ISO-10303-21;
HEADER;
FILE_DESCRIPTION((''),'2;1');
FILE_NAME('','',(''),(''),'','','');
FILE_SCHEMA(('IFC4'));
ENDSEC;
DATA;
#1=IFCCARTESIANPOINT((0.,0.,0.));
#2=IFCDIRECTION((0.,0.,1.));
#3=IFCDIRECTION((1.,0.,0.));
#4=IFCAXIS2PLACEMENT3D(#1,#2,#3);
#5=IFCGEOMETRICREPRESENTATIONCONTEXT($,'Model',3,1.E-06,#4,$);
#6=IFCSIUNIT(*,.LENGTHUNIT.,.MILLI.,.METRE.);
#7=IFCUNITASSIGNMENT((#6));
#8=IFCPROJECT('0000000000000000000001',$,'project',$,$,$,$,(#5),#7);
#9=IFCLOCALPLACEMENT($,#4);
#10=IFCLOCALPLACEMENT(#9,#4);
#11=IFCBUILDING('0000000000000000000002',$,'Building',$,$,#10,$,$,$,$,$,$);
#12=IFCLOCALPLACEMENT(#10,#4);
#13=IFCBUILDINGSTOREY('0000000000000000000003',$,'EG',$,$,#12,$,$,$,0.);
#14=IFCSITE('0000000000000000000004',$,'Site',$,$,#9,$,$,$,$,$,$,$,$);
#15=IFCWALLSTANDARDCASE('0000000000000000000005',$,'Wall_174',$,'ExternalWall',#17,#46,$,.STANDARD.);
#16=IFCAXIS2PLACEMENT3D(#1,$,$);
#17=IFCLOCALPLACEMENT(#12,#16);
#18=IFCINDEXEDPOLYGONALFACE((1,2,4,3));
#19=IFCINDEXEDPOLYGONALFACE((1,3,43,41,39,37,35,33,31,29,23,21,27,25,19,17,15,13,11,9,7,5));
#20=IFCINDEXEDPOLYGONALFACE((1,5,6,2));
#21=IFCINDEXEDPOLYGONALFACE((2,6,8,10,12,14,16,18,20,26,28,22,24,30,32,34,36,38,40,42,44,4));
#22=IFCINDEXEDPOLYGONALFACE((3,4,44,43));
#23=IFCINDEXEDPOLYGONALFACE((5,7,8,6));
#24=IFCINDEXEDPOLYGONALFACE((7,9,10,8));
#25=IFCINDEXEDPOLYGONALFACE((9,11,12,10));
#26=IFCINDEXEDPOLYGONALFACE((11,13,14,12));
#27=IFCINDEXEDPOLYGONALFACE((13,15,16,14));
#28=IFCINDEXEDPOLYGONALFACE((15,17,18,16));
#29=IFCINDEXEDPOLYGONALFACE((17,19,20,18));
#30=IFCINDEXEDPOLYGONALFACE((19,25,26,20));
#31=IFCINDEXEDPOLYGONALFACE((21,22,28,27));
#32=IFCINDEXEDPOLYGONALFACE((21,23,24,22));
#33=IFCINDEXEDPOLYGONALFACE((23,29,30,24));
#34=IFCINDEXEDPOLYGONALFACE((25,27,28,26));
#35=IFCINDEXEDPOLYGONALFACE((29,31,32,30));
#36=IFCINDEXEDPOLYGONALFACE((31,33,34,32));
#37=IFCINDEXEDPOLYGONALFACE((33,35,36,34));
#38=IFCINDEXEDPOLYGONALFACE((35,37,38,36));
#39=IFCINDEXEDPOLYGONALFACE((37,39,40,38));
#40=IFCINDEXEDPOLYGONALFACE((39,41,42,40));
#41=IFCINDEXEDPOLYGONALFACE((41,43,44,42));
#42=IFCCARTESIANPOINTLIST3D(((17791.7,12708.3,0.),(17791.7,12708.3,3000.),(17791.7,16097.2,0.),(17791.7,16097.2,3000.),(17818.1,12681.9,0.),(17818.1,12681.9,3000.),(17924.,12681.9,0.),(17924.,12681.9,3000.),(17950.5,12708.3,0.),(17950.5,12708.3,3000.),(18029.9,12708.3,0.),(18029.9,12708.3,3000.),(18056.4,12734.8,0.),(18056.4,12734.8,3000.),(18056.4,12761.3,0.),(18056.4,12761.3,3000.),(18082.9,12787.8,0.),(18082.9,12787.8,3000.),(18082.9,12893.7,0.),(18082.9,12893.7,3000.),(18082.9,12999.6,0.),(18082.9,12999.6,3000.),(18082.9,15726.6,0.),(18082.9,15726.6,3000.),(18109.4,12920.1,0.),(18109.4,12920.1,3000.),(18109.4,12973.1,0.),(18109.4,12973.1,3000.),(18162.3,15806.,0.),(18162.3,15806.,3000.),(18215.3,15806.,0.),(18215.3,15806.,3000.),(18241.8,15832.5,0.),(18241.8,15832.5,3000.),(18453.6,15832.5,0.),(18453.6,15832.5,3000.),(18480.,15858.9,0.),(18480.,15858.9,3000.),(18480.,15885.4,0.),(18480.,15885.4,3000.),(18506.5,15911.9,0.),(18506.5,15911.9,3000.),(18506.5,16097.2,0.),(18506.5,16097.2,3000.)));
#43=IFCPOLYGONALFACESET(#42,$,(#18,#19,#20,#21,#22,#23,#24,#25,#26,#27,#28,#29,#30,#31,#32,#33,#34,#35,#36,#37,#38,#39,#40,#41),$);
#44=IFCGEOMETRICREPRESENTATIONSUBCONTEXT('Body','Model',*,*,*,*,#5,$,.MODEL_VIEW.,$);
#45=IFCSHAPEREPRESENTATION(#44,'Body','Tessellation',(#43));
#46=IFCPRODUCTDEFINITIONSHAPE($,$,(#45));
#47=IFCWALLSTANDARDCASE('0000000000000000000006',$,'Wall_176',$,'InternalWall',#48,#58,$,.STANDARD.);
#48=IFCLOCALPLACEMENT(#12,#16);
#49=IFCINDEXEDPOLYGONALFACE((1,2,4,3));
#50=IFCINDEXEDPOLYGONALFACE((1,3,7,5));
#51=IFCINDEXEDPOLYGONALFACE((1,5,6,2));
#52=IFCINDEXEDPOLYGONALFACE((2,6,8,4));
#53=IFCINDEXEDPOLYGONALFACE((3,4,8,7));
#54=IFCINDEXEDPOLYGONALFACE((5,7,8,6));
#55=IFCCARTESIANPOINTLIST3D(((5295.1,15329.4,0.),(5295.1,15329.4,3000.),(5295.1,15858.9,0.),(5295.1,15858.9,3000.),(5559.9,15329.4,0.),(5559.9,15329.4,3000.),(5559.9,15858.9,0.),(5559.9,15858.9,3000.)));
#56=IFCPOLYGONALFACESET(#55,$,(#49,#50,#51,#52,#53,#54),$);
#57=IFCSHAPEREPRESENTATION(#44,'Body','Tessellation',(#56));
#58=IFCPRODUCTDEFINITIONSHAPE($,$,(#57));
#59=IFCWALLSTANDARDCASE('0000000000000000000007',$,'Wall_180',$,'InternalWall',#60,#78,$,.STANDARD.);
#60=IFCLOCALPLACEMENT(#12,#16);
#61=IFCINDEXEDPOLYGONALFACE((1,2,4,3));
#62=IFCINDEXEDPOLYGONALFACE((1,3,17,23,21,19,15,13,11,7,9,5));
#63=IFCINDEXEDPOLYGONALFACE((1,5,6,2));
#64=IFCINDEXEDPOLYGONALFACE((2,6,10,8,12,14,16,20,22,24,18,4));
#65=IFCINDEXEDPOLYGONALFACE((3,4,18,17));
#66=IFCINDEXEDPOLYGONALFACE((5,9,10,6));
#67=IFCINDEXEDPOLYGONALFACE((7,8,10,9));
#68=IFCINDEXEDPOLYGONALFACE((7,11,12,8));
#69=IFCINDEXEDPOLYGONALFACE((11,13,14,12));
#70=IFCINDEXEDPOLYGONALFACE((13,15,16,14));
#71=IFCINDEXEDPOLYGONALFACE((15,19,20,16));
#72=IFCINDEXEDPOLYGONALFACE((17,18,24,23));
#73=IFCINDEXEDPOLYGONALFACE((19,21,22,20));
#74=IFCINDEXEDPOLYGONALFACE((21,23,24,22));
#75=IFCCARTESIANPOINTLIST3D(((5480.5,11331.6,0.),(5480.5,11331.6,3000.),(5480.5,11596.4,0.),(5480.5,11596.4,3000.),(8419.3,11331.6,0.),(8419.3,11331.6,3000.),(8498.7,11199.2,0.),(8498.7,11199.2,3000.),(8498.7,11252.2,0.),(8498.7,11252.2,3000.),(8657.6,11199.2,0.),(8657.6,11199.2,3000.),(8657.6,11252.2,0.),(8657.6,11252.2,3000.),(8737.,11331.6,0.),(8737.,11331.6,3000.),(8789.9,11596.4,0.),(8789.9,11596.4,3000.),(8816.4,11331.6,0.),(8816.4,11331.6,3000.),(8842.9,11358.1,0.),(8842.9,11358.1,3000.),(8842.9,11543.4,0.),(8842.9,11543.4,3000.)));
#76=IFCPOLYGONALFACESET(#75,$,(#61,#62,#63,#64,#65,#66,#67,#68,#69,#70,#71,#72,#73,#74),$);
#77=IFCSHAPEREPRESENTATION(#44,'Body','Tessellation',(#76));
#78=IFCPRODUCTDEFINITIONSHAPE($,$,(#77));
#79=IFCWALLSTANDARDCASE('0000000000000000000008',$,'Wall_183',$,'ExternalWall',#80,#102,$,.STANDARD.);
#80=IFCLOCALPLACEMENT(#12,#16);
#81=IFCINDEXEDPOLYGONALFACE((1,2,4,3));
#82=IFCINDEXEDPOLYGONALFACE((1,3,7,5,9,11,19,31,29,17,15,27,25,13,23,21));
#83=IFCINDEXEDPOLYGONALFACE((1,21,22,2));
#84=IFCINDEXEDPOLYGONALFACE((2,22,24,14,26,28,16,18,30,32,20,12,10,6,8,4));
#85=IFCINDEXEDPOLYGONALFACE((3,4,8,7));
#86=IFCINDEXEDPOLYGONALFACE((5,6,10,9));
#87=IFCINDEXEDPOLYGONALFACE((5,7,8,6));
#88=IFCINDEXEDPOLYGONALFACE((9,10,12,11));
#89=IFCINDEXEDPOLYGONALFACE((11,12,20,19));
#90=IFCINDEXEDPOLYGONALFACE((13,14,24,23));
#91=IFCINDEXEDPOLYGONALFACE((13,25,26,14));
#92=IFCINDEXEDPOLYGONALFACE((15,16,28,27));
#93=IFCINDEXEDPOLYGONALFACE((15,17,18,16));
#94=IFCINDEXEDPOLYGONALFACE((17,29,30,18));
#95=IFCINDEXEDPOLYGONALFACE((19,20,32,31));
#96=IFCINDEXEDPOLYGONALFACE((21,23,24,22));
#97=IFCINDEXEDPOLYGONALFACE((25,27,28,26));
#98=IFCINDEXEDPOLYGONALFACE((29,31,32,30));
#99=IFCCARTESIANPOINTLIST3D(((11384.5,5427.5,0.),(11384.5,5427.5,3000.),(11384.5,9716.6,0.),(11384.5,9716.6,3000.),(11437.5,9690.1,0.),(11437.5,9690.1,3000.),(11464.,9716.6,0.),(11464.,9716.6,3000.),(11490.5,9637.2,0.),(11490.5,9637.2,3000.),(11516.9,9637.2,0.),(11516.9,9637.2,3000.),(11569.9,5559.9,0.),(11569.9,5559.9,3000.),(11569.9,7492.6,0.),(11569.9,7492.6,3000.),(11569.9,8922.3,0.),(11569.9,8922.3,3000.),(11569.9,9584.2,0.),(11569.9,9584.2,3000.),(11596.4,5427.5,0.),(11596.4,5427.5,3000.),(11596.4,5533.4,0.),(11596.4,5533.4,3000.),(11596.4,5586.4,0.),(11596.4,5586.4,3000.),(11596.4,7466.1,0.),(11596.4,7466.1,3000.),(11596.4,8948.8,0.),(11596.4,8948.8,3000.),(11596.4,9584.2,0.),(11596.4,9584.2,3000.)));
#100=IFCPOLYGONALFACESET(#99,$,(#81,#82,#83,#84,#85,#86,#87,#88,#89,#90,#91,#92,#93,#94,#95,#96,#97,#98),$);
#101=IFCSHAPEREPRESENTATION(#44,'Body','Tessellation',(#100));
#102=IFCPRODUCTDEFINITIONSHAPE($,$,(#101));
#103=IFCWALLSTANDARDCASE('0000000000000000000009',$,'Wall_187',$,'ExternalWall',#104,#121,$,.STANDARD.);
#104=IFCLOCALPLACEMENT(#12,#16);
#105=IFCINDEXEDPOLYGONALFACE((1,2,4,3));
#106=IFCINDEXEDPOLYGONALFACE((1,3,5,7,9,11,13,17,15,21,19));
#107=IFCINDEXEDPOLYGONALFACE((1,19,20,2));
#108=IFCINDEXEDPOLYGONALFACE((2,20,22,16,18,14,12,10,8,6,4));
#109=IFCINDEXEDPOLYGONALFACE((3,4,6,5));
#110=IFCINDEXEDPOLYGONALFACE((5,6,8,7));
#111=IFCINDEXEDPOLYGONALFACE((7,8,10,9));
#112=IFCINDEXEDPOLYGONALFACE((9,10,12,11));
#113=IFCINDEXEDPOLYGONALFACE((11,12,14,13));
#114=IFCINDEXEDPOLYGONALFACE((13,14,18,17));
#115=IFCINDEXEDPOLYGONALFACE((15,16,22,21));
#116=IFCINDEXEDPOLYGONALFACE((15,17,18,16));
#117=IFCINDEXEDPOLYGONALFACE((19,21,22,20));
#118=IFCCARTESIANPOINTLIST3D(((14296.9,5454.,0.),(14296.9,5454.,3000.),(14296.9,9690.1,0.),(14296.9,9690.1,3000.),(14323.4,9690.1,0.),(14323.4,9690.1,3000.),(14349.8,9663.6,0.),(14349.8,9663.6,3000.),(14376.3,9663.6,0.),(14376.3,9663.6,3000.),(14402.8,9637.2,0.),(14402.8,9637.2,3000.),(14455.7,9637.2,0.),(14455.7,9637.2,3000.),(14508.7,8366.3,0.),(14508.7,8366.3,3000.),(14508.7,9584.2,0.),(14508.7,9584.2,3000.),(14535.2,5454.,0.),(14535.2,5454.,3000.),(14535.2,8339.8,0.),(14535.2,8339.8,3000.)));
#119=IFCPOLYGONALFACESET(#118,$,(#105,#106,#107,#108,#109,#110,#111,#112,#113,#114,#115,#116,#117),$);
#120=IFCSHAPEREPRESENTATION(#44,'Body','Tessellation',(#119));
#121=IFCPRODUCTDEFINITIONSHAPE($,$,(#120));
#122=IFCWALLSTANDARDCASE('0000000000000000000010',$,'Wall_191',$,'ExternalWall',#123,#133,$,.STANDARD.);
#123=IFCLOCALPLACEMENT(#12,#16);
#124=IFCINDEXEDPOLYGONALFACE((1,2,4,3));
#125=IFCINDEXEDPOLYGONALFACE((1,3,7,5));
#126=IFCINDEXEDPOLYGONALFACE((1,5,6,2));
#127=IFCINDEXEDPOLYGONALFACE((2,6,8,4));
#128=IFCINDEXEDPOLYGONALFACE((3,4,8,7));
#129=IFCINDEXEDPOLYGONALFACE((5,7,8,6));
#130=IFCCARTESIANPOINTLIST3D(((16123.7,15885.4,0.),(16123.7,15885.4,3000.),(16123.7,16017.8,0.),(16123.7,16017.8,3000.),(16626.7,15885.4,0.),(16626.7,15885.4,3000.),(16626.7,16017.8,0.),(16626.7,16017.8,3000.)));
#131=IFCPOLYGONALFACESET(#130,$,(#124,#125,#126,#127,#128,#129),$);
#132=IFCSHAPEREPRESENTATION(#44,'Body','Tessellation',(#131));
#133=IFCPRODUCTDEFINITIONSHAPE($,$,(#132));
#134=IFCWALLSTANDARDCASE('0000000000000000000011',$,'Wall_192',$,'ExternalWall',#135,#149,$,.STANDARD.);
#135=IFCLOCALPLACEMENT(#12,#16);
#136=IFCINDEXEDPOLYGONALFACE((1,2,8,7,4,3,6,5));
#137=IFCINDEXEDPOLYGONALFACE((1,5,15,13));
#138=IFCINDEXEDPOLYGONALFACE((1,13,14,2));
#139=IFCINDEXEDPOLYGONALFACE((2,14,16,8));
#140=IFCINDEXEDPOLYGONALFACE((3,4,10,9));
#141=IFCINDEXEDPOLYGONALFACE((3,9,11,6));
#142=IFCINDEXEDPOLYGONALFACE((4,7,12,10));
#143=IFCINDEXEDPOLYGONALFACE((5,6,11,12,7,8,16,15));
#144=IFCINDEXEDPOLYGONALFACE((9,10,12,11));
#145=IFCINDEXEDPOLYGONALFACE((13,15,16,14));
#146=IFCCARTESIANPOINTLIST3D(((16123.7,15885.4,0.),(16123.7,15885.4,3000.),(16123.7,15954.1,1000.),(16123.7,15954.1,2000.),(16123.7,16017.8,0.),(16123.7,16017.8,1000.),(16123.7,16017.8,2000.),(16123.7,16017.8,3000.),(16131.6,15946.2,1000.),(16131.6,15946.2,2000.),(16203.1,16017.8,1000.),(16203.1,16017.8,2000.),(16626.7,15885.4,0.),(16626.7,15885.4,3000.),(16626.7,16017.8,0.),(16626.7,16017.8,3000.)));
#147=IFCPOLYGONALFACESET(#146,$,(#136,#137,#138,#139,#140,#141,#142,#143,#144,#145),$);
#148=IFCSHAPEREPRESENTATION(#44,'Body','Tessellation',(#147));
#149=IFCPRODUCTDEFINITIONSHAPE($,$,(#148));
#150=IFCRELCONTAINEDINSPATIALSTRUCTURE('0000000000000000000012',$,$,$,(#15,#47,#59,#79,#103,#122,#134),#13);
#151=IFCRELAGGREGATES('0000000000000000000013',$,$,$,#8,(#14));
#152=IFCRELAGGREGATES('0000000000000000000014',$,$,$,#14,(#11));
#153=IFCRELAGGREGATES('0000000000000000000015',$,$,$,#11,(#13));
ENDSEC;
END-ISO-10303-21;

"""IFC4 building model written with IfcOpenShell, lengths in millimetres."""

from ifc_helpers import new_model, si_unit, frame, origin_with_axes, place, context, subcontext, project, spatial, polyline, rectangle, outline, extrude, element, save


model = new_model("IFC4")

# Units and contexts
model_context = context("Model", 3, precision=1e-06, world=origin_with_axes())
body_context = subcontext(model_context, "Body", "Model", "MODEL_VIEW")
ifc_project = project(units=[si_unit("LENGTHUNIT", "METRE", prefix="MILLI")], contexts=[model_context])

# Site, building, storey
site_placement = place(None, origin_with_axes())
site = spatial("IfcSite", under=ifc_project, at=site_placement, Name="Site")
building_placement = place(site_placement, origin_with_axes())
building = spatial("IfcBuilding", under=site, at=building_placement, Name="Building")
storey_placement = place(building_placement, origin_with_axes())
storey = spatial("IfcBuildingStorey", under=building, at=storey_placement, Name="EG", Elevation=0.0)

# Walls
for number, where, z_axis, x_axis, name in (
    (1, (0.0, 0.0, 0.0), (0.0, 0.0, 1.0), (1.0, 0.0, 0.0), "Wall_174"),
):
    element("IfcWallStandardCase", number, at=place(storey_placement, frame(where, z_axis=z_axis, x_axis=x_axis)), inside=storey, Name=name, ObjectType="ExternalWall", PredefinedType="STANDARD", context=body_context, shape_type="SweptSolid", body=[
        extrude(outline(polyline([(17818.1, 12681.9, 0.0), (17791.7, 12708.3, 0.0), (17791.7, 16097.2, 0.0), (18506.5, 16097.2, 0.0), (18506.5, 15911.9, 0.0), (18480.0, 15885.4, 0.0), (18480.0, 15858.9, 0.0), (18453.6, 15832.5, 0.0), (18241.8, 15832.5, 0.0), (18215.3, 15806.0, 0.0), (18162.3, 15806.0, 0.0), (18082.9, 15726.6, 0.0), (18082.9, 12999.6, 0.0), (18109.4, 12973.1, 0.0), (18109.4, 12920.1, 0.0), (18082.9, 12893.7, 0.0), (18082.9, 12787.8, 0.0), (18056.4, 12761.3, 0.0), (18056.4, 12734.8, 0.0), (18029.9, 12708.3, 0.0), (17950.5, 12708.3, 0.0), (17924.0, 12681.9, 0.0), (17818.1, 12681.9, 0.0)])), origin_with_axes(), (0.0, 0.0, 1.0), 3000.0),
    ])
for number, where, z_axis, x_axis, name in (
    (2, (0.0, 0.0, 0.0), (0.0, 0.0, 1.0), (1.0, 0.0, 0.0), "Wall_176"),
):
    element("IfcWallStandardCase", number, at=place(storey_placement, frame(where, z_axis=z_axis, x_axis=x_axis)), inside=storey, Name=name, ObjectType="InternalWall", PredefinedType="STANDARD", context=body_context, shape_type="SweptSolid", body=[
        extrude(outline(polyline([(5295.1, 15329.4, 0.0), (5295.1, 15858.9, 0.0), (5559.9, 15858.9, 0.0), (5559.9, 15329.4, 0.0), (5295.1, 15329.4, 0.0)])), origin_with_axes(), (0.0, 0.0, 1.0), 3000.0),
    ])
for number, where, z_axis, x_axis, name in (
    (3, (0.0, 0.0, 0.0), (0.0, 0.0, 1.0), (1.0, 0.0, 0.0), "Wall_180"),
):
    element("IfcWallStandardCase", number, at=place(storey_placement, frame(where, z_axis=z_axis, x_axis=x_axis)), inside=storey, Name=name, ObjectType="InternalWall", PredefinedType="STANDARD", context=body_context, shape_type="SweptSolid", body=[
        extrude(outline(polyline([(8498.7, 11199.2, 0.0), (8498.7, 11252.2, 0.0), (8419.3, 11331.6, 0.0), (5480.5, 11331.6, 0.0), (5480.5, 11596.4, 0.0), (8789.9, 11596.4, 0.0), (8842.9, 11543.4, 0.0), (8842.9, 11358.1, 0.0), (8816.4, 11331.6, 0.0), (8737.0, 11331.6, 0.0), (8657.6, 11252.2, 0.0), (8657.6, 11199.2, 0.0), (8498.7, 11199.2, 0.0)])), origin_with_axes(), (0.0, 0.0, 1.0), 3000.0),
    ])
for number, where, z_axis, x_axis, name in (
    (4, (0.0, 0.0, 0.0), (0.0, 0.0, 1.0), (1.0, 0.0, 0.0), "Wall_183"),
):
    element("IfcWallStandardCase", number, at=place(storey_placement, frame(where, z_axis=z_axis, x_axis=x_axis)), inside=storey, Name=name, ObjectType="ExternalWall", PredefinedType="STANDARD", context=body_context, shape_type="SweptSolid", body=[
        extrude(outline(polyline([(11384.5, 5427.5, 0.0), (11384.5, 9716.6, 0.0), (11464.0, 9716.6, 0.0), (11437.5, 9690.1, 0.0), (11490.5, 9637.2, 0.0), (11516.9, 9637.2, 0.0), (11569.9, 9584.2, 0.0), (11596.4, 9584.2, 0.0), (11596.4, 8948.8, 0.0), (11569.9, 8922.3, 0.0), (11569.9, 7492.6, 0.0), (11596.4, 7466.1, 0.0), (11596.4, 5586.4, 0.0), (11569.9, 5559.9, 0.0), (11596.4, 5533.4, 0.0), (11596.4, 5427.5, 0.0), (11384.5, 5427.5, 0.0)])), origin_with_axes(), (0.0, 0.0, 1.0), 3000.0),
    ])
for number, where, z_axis, x_axis, name in (
    (5, (0.0, 0.0, 0.0), (0.0, 0.0, 1.0), (1.0, 0.0, 0.0), "Wall_187"),
):
    element("IfcWallStandardCase", number, at=place(storey_placement, frame(where, z_axis=z_axis, x_axis=x_axis)), inside=storey, Name=name, ObjectType="ExternalWall", PredefinedType="STANDARD", context=body_context, shape_type="SweptSolid", body=[
        extrude(outline(polyline([(14296.9, 5454.0, 0.0), (14296.9, 9690.1, 0.0), (14323.4, 9690.1, 0.0), (14349.8, 9663.6, 0.0), (14376.3, 9663.6, 0.0), (14402.8, 9637.2, 0.0), (14455.7, 9637.2, 0.0), (14508.7, 9584.2, 0.0), (14508.7, 8366.3, 0.0), (14535.2, 8339.8, 0.0), (14535.2, 5454.0, 0.0), (14296.9, 5454.0, 0.0)])), origin_with_axes(), (0.0, 0.0, 1.0), 3000.0),
    ])
wall_1_placement = place(storey_placement, origin_with_axes())
element("IfcWallStandardCase", 6, at=wall_1_placement, inside=storey, Name="Wall_191", ObjectType="ExternalWall", PredefinedType="STANDARD", context=body_context, shape_type="SweptSolid", body=[
    extrude(outline(polyline([(16123.7, 15885.4, 0.0), (16123.7, 16017.8, 0.0), (16626.7, 16017.8, 0.0), (16626.7, 15885.4, 0.0), (16123.7, 15885.4, 0.0)])), origin_with_axes(), (0.0, 0.0, 1.0), 3000.0),
])

# Wall, opening
wall_2_placement = place(storey_placement, origin_with_axes())
wall_2 = element("IfcWallStandardCase", 7, at=wall_2_placement, inside=storey, Name="Wall_192", ObjectType="ExternalWall", PredefinedType="STANDARD", context=body_context, shape_type="SweptSolid", body=[
    extrude(outline(polyline([(16123.7, 15885.4, 0.0), (16123.7, 16017.8, 0.0), (16626.7, 16017.8, 0.0), (16626.7, 15885.4, 0.0), (16123.7, 15885.4, 0.0)])), origin_with_axes(), (0.0, 0.0, 1.0), 3000.0),
])
opening_placement = place(wall_2_placement, origin_with_axes())
element("IfcOpeningElement", 8, at=opening_placement, inside=storey, cuts=wall_2, context=body_context, shape_type="SweptSolid", body=[
    extrude(rectangle(XDim=842.5, YDim=115.0), frame((15874.4, 16284.7, 1000.0), z_axis=(0.0, 0.0, 1.0), x_axis=(-0.707107, 0.707107, 0.0)), (0.0, 0.0, 1.0), 1000.0),
])

save(model, "model.ifc")
